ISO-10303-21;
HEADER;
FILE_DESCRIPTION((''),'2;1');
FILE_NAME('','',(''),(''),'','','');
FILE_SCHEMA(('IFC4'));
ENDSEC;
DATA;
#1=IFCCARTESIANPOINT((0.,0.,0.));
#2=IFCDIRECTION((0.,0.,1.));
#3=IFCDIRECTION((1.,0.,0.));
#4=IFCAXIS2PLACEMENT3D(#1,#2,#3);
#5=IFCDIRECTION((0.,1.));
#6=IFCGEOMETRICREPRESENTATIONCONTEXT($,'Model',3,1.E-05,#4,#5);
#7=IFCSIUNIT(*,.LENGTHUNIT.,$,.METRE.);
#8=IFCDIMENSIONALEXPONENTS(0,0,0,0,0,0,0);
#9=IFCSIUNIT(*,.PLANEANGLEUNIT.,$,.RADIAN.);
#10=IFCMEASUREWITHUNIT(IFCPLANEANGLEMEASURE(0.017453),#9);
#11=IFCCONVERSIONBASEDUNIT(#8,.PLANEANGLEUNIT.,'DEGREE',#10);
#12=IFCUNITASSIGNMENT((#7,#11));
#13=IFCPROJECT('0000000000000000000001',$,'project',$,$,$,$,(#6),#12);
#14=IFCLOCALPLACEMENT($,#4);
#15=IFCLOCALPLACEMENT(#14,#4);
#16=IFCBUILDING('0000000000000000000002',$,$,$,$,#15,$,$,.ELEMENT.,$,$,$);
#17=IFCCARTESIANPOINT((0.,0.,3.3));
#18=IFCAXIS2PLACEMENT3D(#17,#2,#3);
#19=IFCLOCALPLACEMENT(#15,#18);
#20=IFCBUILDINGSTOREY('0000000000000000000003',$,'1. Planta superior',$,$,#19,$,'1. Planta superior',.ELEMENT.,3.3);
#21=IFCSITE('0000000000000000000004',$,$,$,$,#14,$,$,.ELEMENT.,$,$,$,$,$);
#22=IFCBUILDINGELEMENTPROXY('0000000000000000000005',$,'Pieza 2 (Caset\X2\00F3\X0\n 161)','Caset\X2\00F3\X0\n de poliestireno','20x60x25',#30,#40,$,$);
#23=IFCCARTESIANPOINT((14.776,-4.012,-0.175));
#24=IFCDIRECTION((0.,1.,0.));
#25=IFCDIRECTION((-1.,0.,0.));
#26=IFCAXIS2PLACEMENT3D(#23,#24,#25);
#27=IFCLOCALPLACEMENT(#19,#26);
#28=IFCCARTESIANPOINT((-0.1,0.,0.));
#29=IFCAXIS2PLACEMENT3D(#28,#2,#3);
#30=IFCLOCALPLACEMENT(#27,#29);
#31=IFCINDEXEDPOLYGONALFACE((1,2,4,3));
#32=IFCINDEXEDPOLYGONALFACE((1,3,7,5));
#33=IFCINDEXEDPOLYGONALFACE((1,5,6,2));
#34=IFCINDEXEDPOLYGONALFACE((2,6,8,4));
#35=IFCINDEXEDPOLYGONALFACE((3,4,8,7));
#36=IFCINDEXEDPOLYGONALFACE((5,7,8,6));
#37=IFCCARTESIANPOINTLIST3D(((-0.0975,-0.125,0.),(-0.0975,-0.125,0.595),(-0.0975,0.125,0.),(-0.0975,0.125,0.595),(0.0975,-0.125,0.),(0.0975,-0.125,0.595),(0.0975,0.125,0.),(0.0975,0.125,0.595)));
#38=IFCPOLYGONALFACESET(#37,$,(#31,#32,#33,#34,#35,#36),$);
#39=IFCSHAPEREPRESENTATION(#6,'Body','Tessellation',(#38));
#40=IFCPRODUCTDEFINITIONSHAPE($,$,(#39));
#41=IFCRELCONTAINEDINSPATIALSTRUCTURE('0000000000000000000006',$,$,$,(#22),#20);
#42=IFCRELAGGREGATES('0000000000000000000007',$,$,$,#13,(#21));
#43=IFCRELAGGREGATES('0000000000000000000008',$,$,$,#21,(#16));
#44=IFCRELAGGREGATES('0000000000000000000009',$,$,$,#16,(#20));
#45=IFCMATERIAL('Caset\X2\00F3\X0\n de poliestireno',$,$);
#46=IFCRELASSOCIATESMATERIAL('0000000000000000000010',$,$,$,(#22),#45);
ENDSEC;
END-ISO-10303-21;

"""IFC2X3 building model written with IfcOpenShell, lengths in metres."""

from ifc_helpers import new_model, entity, si_unit, converted_unit, direction, frame, origin_with_axes, origin_2d_with_axis, place, context, project, spatial, rectangle, extrude, source, transform, mapped, material, element, save


model = new_model("IFC2X3")

# Units and contexts
model_context = context("Model", 3, precision=1e-05, world=origin_with_axes(), true_north=direction((0.0, 1.0)))
ifc_project = project(units=[si_unit("LENGTHUNIT", "METRE"), converted_unit("PLANEANGLEUNIT", "DEGREE", entity("IfcPlaneAngleMeasure", 0.017453), si_unit("PLANEANGLEUNIT", "RADIAN"), dimensions=[0, 0, 0, 0, 0, 0, 0])], contexts=[model_context])

# Site, building, storey
site_placement = place(None, origin_with_axes())
site = spatial("IfcSite", under=ifc_project, at=site_placement, CompositionType="ELEMENT")
building_placement = place(site_placement, origin_with_axes())
building = spatial("IfcBuilding", under=site, at=building_placement, CompositionType="ELEMENT")
storey_placement = place(building_placement, frame((0.0, 0.0, 3.3), z_axis=(0.0, 0.0, 1.0), x_axis=(1.0, 0.0, 0.0)))
storey = spatial("IfcBuildingStorey", under=building, at=storey_placement, Name="1. Planta superior", LongName="1. Planta superior", CompositionType="ELEMENT", Elevation=3.3)

# Building element proxy
ifc_material = material(Name="Casetón de poliestireno")
shared_shape = source(origin_with_axes(), model_context, "Body", "SweptSolid", [
    extrude(rectangle(XDim=0.195, YDim=0.25, at=origin_2d_with_axis()), origin_with_axes(), (0.0, 0.0, 1.0), 0.595),
])
placement_1 = place(storey_placement, frame((14.776, -4.012, -0.175), z_axis=(0.0, 1.0, 0.0), x_axis=(-1.0, 0.0, 0.0)))
for number, where, z_axis, x_axis, name in (
    (1, (-0.1, 0.0, 0.0), (0.0, 0.0, 1.0), (1.0, 0.0, 0.0), "Pieza 2 (Casetón 161)"),
):
    element("IfcBuildingElementProxy", number, at=place(placement_1, frame(where, z_axis=z_axis, x_axis=x_axis)), inside=storey, material=ifc_material, Name=name, Description="Casetón de poliestireno", ObjectType="20x60x25", context=model_context, shape_type="MappedRepresentation", body=[
        mapped(shared_shape, transform((0.0, 0.0, 0.0), x_axis=(1.0, 0.0, 0.0), y_axis=(0.0, 1.0, 0.0), z_axis=(0.0, 0.0, 1.0))),
    ])

save(model, "model.ifc")
